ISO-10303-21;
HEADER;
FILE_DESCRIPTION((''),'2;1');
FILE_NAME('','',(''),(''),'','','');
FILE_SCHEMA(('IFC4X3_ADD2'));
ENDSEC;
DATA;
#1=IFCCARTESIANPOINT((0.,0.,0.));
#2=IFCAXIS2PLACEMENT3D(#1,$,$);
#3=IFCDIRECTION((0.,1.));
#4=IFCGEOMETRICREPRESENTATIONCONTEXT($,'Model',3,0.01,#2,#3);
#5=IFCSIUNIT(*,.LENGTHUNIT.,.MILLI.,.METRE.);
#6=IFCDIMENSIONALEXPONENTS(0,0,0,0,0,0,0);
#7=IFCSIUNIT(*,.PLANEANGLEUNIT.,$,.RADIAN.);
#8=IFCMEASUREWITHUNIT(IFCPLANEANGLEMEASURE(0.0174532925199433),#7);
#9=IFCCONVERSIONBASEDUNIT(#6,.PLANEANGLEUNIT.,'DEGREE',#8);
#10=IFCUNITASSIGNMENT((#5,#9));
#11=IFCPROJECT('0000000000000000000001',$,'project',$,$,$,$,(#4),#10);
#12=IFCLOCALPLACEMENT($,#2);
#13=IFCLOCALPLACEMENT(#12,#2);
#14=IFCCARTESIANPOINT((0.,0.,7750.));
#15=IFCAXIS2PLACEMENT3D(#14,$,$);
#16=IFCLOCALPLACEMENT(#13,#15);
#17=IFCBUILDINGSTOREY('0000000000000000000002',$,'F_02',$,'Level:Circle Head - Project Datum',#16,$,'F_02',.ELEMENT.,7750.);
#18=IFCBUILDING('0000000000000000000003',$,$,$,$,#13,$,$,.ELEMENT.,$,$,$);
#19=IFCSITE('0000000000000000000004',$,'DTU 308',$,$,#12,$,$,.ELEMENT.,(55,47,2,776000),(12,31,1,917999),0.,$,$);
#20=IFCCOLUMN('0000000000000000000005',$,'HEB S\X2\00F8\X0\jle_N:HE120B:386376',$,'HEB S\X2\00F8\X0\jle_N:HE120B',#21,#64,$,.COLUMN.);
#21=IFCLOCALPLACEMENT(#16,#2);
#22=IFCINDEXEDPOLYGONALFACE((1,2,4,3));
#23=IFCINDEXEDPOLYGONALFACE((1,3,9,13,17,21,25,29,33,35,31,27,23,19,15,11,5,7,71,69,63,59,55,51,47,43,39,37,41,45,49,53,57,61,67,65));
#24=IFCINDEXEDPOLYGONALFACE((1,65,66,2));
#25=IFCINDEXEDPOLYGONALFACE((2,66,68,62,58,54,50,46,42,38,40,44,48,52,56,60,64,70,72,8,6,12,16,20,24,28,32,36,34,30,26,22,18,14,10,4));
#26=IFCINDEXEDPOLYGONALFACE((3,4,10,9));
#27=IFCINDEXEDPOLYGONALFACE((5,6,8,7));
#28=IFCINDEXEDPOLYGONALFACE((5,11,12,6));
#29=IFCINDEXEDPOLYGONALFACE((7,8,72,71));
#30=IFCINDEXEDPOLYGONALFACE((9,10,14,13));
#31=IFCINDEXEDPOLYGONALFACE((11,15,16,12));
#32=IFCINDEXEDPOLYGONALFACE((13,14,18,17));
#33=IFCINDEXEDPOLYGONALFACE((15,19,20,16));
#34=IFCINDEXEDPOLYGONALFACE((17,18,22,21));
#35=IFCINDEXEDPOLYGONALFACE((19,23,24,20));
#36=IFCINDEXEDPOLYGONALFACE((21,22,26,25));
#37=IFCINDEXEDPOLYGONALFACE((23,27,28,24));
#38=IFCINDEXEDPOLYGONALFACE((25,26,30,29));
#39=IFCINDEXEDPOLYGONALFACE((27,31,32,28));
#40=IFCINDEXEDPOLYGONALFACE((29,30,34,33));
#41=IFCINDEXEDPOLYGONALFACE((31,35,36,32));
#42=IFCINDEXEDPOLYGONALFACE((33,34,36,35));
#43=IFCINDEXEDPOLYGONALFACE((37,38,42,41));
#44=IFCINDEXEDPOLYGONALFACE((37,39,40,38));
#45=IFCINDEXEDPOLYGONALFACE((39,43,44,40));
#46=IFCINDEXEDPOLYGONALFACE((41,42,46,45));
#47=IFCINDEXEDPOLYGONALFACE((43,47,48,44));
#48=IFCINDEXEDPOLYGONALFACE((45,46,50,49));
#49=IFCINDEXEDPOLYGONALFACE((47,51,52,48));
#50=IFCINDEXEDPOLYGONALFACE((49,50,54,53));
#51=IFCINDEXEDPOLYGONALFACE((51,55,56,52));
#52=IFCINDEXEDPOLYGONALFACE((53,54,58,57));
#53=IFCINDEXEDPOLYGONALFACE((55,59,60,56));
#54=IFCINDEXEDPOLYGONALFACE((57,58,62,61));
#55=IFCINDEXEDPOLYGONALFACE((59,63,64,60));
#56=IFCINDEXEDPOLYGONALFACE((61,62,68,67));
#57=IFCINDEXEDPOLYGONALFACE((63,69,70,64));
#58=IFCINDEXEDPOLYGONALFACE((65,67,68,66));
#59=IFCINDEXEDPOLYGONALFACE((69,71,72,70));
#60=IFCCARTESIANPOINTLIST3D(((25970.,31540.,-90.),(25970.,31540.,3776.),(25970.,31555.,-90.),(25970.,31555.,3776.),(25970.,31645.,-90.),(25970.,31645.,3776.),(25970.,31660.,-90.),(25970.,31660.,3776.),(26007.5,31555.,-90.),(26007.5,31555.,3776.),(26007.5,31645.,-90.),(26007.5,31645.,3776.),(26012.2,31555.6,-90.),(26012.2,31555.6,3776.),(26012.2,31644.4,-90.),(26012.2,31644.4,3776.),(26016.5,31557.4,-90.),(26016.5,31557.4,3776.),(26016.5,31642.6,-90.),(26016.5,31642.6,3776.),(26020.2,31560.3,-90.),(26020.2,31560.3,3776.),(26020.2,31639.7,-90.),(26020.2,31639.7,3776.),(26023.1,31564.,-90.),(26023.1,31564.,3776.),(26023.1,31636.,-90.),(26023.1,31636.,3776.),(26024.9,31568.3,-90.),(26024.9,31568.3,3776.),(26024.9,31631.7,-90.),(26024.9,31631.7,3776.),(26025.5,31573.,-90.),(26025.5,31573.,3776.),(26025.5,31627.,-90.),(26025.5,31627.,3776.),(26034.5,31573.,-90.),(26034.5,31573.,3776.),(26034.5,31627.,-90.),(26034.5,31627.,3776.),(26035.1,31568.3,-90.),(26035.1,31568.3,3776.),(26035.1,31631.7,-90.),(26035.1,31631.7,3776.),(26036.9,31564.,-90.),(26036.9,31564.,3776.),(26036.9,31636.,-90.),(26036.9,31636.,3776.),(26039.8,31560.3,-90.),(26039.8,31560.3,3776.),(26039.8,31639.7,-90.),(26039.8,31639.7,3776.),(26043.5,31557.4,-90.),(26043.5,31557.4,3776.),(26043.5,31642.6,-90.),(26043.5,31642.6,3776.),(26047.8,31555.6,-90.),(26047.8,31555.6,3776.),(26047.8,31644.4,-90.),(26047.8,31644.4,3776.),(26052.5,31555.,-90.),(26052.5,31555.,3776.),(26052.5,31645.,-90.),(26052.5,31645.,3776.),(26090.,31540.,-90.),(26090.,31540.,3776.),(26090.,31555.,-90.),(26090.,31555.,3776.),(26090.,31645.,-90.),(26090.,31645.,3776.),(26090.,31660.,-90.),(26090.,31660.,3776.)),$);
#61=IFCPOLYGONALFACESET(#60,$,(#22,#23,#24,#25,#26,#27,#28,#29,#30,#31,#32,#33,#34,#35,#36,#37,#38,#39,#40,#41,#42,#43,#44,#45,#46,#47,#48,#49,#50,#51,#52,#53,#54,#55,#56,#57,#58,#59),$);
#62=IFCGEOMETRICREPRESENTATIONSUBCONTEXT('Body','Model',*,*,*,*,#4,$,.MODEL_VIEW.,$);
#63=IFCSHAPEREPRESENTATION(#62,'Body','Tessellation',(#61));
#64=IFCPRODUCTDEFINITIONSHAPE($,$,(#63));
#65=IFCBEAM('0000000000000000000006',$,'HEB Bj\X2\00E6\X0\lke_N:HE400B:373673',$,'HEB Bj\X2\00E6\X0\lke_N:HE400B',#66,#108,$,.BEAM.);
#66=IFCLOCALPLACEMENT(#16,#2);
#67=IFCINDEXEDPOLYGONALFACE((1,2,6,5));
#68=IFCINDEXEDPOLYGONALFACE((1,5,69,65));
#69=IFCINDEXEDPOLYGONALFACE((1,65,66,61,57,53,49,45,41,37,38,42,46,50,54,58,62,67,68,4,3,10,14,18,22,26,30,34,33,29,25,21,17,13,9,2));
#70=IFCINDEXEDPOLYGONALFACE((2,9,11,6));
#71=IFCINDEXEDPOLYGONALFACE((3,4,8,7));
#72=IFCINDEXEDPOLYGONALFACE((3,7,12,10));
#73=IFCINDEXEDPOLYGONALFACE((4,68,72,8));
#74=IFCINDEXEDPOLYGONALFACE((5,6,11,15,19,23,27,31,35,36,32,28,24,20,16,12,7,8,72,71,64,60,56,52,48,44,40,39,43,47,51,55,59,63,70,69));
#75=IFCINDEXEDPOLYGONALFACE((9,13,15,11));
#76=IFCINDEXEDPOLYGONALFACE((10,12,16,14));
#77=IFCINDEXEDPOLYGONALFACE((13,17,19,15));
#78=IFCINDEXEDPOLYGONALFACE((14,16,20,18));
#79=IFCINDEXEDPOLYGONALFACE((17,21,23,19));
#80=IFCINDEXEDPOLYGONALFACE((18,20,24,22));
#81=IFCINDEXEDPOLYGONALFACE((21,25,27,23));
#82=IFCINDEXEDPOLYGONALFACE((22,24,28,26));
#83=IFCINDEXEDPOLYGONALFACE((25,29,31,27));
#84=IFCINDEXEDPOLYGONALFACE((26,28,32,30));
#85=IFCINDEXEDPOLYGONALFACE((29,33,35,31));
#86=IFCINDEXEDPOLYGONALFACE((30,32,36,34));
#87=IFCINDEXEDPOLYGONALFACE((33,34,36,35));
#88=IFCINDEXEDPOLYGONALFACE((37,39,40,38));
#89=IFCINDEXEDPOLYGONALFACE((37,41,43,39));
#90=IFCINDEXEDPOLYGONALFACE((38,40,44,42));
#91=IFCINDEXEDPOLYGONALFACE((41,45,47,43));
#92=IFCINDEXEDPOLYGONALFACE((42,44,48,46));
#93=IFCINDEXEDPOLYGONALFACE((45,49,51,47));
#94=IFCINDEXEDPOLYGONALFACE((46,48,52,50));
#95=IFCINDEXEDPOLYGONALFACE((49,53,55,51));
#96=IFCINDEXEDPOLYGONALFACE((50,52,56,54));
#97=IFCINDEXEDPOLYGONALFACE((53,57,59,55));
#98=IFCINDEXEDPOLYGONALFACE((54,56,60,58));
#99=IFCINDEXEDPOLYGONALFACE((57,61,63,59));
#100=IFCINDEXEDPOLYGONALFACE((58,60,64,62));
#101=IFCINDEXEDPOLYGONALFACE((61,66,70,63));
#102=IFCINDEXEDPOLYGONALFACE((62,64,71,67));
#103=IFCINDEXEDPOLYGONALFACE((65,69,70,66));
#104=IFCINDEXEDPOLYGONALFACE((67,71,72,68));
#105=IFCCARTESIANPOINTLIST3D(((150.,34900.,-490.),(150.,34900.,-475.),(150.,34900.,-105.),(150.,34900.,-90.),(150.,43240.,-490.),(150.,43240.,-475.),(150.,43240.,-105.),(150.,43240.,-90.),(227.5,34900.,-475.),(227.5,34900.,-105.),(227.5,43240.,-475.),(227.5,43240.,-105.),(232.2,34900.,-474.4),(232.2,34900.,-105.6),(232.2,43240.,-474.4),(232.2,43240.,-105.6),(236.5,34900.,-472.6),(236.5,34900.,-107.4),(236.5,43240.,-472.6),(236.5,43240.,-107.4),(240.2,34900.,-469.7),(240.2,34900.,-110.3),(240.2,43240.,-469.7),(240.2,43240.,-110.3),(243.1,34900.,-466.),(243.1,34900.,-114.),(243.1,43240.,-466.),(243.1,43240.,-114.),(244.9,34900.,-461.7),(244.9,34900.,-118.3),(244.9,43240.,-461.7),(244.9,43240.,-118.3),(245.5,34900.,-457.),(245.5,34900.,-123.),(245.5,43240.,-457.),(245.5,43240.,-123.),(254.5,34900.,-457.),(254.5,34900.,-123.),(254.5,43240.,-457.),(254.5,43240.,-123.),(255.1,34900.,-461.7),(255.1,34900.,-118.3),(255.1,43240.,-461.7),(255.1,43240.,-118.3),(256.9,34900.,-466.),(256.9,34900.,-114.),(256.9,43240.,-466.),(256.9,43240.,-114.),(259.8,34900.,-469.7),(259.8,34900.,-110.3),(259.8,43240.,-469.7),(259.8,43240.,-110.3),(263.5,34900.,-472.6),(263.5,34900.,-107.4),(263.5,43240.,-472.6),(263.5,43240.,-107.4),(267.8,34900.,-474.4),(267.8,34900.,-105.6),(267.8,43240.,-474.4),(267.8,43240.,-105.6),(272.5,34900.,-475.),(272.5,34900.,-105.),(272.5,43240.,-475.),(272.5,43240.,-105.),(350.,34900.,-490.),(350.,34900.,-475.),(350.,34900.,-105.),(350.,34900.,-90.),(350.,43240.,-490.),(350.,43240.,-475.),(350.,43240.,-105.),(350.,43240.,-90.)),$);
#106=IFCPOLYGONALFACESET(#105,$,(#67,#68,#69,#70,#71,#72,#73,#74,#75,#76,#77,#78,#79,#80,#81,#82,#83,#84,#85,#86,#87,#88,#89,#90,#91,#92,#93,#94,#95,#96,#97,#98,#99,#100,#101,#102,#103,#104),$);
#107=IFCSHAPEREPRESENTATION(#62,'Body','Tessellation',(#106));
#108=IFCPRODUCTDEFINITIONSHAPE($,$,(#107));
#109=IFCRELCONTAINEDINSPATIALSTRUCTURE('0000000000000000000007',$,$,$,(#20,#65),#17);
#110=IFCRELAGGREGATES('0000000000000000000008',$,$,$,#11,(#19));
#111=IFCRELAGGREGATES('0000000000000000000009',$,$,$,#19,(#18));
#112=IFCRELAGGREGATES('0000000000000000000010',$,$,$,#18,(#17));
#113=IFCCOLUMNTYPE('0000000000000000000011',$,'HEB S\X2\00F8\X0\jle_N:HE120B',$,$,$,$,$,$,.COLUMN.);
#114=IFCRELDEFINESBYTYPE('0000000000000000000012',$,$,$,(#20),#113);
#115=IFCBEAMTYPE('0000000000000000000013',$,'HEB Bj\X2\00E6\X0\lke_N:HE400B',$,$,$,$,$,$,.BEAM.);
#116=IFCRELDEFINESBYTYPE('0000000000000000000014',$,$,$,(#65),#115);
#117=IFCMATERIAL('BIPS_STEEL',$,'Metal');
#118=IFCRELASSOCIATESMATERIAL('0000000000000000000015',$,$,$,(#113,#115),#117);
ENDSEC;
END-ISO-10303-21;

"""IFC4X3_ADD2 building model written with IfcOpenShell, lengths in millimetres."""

from ifc_helpers import new_model, entity, si_unit, converted_unit, direction, frame, frame_2d, origin, place, context, subcontext, project, spatial, polyline, circle_curve, parameter, trimmed, segment, composite_curve, i_section, outline, extrude, source, transform, mapped, material, material_profile, profile_set, type_object, element, save


model = new_model("IFC4X3_ADD2")

# Units and contexts
model_context = context("Model", 3, precision=0.01, world=origin(), true_north=direction((0.0, 1.0)))
body_context = subcontext(model_context, "Body", "Model", "MODEL_VIEW")
ifc_project = project(units=[si_unit("LENGTHUNIT", "METRE", prefix="MILLI"), converted_unit("PLANEANGLEUNIT", "DEGREE", entity("IfcPlaneAngleMeasure", 0.0174532925199433), si_unit("PLANEANGLEUNIT", "RADIAN"), dimensions=[0, 0, 0, 0, 0, 0, 0])], contexts=[model_context])

# Site, building, storey
site_placement = place(None, origin())
site = spatial("IfcSite", under=ifc_project, at=site_placement, Name="DTU 308", CompositionType="ELEMENT", RefLatitude=(55, 47, 2, 776000), RefLongitude=(12, 31, 1, 917999), RefElevation=0.0)
building_placement = place(site_placement, origin())
building = spatial("IfcBuilding", under=site, at=building_placement, CompositionType="ELEMENT")
storey_placement = place(building_placement, frame((0.0, 0.0, 7750.0)))
storey = spatial("IfcBuildingStorey", under=building, at=storey_placement, Name="F_02", ObjectType="Level:Circle Head - Project Datum", LongName="F_02", CompositionType="ELEMENT", Elevation=7750.0)

# Column
ifc_material = material(Name="BIPS_STEEL", Category="Metal")
ifc_material_profile_1 = material_profile(ifc_material, i_section(OverallWidth=120.0, OverallDepth=120.0, WebThickness=9.0, FlangeThickness=15.0, FilletRadius=18.0, at=frame_2d((0.0, 0.0), x_axis=(1.0, 0.0))), Name="HE120B")
ifc_profile_set_1 = profile_set([ifc_material_profile_1], Name="HE120B")
column_type_1 = type_object("IfcColumnType", Name="HEB Søjle_N:HE120B", PredefinedType="COLUMN", material=ifc_profile_set_1)
shared_shape_1 = source(origin(), body_context, "Body", "SweptSolid", [
    extrude(i_section(OverallWidth=120.0, OverallDepth=120.0, WebThickness=9.0, FlangeThickness=15.0, FilletRadius=18.0, at=frame_2d((0.0, 0.0), x_axis=(1.0, 0.0))), frame((0.0, 0.0, 7660.0), z_axis=(0.0, 0.0, 1.0), x_axis=(-1.0, 0.0, 0.0)), (0.0, 0.0, 1.0), 3866.0),
])
column_placement = place(storey_placement, frame((26030.0, 31600.0, -7750.0)))
element("IfcColumn", 1, at=column_placement, inside=storey, type_object=column_type_1, Name="HEB Søjle_N:HE120B:386376", ObjectType="HEB Søjle_N:HE120B", PredefinedType="COLUMN", context=body_context, shape_type="MappedRepresentation", body=[
    mapped(shared_shape_1, transform((0.0, 0.0, 0.0), scale=1.0)),
])

# Beam
ifc_material_profile_2 = material_profile(ifc_material, outline(composite_curve([segment(polyline([(-100.0, -185.0), (-100.0, -200.0)]), True, "CONTINUOUS"), segment(polyline([(-100.0, -200.0), (100.0, -200.0)]), True, "CONTINUOUS"), segment(polyline([(100.0, -200.0), (100.0, -185.0)]), True, "CONTINUOUS"), segment(polyline([(100.0, -185.0), (22.5, -185.0)]), True, "CONTINUOUS"), segment(trimmed(circle_curve(frame_2d((22.5, -167.0), x_axis=(1.0, 0.0)), 18.0), [parameter(180.0)], [parameter(270.0)], True, "PARAMETER"), False, "CONTINUOUS"), segment(polyline([(4.5, -167.0), (4.5, 167.0)]), True, "CONTINUOUS"), segment(trimmed(circle_curve(frame_2d((22.5, 167.0), x_axis=(1.0, 0.0)), 18.0), [parameter(90.0)], [parameter(180.0)], True, "PARAMETER"), False, "CONTINUOUS"), segment(polyline([(22.5, 185.0), (100.0, 185.0)]), True, "CONTINUOUS"), segment(polyline([(100.0, 185.0), (100.0, 200.0)]), True, "CONTINUOUS"), segment(polyline([(100.0, 200.0), (-100.0, 200.0)]), True, "CONTINUOUS"), segment(polyline([(-100.0, 200.0), (-100.0, 185.0)]), True, "CONTINUOUS"), segment(polyline([(-100.0, 185.0), (-22.5, 185.0)]), True, "CONTINUOUS"), segment(trimmed(circle_curve(frame_2d((-22.5, 167.0), x_axis=(1.0, 0.0)), 18.0), [parameter(360.0)], [parameter(90.0)], True, "PARAMETER"), False, "CONTINUOUS"), segment(polyline([(-4.5, 167.0), (-4.5, -167.0)]), True, "CONTINUOUS"), segment(trimmed(circle_curve(frame_2d((-22.5, -167.0), x_axis=(1.0, 0.0)), 18.0), [parameter(270.0)], [parameter(360.0)], True, "PARAMETER"), False, "CONTINUOUS"), segment(polyline([(-22.5, -185.0), (-100.0, -185.0)]), True, "CONTINUOUS")], self_intersect=False)), Name="HE400B")
ifc_profile_set_2 = profile_set([ifc_material_profile_2], Name="HE400B")
beam_type_1 = type_object("IfcBeamType", Name="HEB Bjælke_N:HE400B", PredefinedType="BEAM", material=ifc_profile_set_2)
shared_shape_2 = source(origin(), body_context, "Body", "SweptSolid", [
    extrude(outline(composite_curve([segment(polyline([(-100.0, -185.0), (-100.0, -200.0)]), True, "CONTINUOUS"), segment(polyline([(-100.0, -200.0), (100.0, -200.0)]), True, "CONTINUOUS"), segment(polyline([(100.0, -200.0), (100.0, -185.0)]), True, "CONTINUOUS"), segment(polyline([(100.0, -185.0), (22.5, -185.0)]), True, "CONTINUOUS"), segment(trimmed(circle_curve(frame_2d((22.5, -167.0), x_axis=(1.0, 0.0)), 18.0), [parameter(180.0)], [parameter(270.0)], True, "PARAMETER"), False, "CONTINUOUS"), segment(polyline([(4.5, -167.0), (4.5, 167.0)]), True, "CONTINUOUS"), segment(trimmed(circle_curve(frame_2d((22.5, 167.0), x_axis=(1.0, 0.0)), 18.0), [parameter(90.0)], [parameter(180.0)], True, "PARAMETER"), False, "CONTINUOUS"), segment(polyline([(22.5, 185.0), (100.0, 185.0)]), True, "CONTINUOUS"), segment(polyline([(100.0, 185.0), (100.0, 200.0)]), True, "CONTINUOUS"), segment(polyline([(100.0, 200.0), (-100.0, 200.0)]), True, "CONTINUOUS"), segment(polyline([(-100.0, 200.0), (-100.0, 185.0)]), True, "CONTINUOUS"), segment(polyline([(-100.0, 185.0), (-22.5, 185.0)]), True, "CONTINUOUS"), segment(trimmed(circle_curve(frame_2d((-22.5, 167.0), x_axis=(1.0, 0.0)), 18.0), [parameter(360.0)], [parameter(90.0)], True, "PARAMETER"), False, "CONTINUOUS"), segment(polyline([(-4.5, 167.0), (-4.5, -167.0)]), True, "CONTINUOUS"), segment(trimmed(circle_curve(frame_2d((-22.5, -167.0), x_axis=(1.0, 0.0)), 18.0), [parameter(270.0)], [parameter(360.0)], True, "PARAMETER"), False, "CONTINUOUS"), segment(polyline([(-22.5, -185.0), (-100.0, -185.0)]), True, "CONTINUOUS")], self_intersect=False)), frame((-4279.1, 0.0, 0.0), z_axis=(-1.0, 0.0, 0.0), x_axis=(0.0, -1.0, 0.0)), (0.0, 0.0, -1.0), 8340.0),
])
beam_1_placement = place(storey_placement, frame((250.0, 38960.9, -290.0), z_axis=(0.0, 0.0, 1.0), x_axis=(0.0, -1.0, 0.0)))
element("IfcBeam", 2, at=beam_1_placement, inside=storey, type_object=beam_type_1, Name="HEB Bjælke_N:HE400B:373673", ObjectType="HEB Bjælke_N:HE400B", PredefinedType="BEAM", context=body_context, shape_type="MappedRepresentation", body=[
    mapped(shared_shape_2, transform((0.0, 0.0, 0.0), scale=1.0)),
])

save(model, "model.ifc")
